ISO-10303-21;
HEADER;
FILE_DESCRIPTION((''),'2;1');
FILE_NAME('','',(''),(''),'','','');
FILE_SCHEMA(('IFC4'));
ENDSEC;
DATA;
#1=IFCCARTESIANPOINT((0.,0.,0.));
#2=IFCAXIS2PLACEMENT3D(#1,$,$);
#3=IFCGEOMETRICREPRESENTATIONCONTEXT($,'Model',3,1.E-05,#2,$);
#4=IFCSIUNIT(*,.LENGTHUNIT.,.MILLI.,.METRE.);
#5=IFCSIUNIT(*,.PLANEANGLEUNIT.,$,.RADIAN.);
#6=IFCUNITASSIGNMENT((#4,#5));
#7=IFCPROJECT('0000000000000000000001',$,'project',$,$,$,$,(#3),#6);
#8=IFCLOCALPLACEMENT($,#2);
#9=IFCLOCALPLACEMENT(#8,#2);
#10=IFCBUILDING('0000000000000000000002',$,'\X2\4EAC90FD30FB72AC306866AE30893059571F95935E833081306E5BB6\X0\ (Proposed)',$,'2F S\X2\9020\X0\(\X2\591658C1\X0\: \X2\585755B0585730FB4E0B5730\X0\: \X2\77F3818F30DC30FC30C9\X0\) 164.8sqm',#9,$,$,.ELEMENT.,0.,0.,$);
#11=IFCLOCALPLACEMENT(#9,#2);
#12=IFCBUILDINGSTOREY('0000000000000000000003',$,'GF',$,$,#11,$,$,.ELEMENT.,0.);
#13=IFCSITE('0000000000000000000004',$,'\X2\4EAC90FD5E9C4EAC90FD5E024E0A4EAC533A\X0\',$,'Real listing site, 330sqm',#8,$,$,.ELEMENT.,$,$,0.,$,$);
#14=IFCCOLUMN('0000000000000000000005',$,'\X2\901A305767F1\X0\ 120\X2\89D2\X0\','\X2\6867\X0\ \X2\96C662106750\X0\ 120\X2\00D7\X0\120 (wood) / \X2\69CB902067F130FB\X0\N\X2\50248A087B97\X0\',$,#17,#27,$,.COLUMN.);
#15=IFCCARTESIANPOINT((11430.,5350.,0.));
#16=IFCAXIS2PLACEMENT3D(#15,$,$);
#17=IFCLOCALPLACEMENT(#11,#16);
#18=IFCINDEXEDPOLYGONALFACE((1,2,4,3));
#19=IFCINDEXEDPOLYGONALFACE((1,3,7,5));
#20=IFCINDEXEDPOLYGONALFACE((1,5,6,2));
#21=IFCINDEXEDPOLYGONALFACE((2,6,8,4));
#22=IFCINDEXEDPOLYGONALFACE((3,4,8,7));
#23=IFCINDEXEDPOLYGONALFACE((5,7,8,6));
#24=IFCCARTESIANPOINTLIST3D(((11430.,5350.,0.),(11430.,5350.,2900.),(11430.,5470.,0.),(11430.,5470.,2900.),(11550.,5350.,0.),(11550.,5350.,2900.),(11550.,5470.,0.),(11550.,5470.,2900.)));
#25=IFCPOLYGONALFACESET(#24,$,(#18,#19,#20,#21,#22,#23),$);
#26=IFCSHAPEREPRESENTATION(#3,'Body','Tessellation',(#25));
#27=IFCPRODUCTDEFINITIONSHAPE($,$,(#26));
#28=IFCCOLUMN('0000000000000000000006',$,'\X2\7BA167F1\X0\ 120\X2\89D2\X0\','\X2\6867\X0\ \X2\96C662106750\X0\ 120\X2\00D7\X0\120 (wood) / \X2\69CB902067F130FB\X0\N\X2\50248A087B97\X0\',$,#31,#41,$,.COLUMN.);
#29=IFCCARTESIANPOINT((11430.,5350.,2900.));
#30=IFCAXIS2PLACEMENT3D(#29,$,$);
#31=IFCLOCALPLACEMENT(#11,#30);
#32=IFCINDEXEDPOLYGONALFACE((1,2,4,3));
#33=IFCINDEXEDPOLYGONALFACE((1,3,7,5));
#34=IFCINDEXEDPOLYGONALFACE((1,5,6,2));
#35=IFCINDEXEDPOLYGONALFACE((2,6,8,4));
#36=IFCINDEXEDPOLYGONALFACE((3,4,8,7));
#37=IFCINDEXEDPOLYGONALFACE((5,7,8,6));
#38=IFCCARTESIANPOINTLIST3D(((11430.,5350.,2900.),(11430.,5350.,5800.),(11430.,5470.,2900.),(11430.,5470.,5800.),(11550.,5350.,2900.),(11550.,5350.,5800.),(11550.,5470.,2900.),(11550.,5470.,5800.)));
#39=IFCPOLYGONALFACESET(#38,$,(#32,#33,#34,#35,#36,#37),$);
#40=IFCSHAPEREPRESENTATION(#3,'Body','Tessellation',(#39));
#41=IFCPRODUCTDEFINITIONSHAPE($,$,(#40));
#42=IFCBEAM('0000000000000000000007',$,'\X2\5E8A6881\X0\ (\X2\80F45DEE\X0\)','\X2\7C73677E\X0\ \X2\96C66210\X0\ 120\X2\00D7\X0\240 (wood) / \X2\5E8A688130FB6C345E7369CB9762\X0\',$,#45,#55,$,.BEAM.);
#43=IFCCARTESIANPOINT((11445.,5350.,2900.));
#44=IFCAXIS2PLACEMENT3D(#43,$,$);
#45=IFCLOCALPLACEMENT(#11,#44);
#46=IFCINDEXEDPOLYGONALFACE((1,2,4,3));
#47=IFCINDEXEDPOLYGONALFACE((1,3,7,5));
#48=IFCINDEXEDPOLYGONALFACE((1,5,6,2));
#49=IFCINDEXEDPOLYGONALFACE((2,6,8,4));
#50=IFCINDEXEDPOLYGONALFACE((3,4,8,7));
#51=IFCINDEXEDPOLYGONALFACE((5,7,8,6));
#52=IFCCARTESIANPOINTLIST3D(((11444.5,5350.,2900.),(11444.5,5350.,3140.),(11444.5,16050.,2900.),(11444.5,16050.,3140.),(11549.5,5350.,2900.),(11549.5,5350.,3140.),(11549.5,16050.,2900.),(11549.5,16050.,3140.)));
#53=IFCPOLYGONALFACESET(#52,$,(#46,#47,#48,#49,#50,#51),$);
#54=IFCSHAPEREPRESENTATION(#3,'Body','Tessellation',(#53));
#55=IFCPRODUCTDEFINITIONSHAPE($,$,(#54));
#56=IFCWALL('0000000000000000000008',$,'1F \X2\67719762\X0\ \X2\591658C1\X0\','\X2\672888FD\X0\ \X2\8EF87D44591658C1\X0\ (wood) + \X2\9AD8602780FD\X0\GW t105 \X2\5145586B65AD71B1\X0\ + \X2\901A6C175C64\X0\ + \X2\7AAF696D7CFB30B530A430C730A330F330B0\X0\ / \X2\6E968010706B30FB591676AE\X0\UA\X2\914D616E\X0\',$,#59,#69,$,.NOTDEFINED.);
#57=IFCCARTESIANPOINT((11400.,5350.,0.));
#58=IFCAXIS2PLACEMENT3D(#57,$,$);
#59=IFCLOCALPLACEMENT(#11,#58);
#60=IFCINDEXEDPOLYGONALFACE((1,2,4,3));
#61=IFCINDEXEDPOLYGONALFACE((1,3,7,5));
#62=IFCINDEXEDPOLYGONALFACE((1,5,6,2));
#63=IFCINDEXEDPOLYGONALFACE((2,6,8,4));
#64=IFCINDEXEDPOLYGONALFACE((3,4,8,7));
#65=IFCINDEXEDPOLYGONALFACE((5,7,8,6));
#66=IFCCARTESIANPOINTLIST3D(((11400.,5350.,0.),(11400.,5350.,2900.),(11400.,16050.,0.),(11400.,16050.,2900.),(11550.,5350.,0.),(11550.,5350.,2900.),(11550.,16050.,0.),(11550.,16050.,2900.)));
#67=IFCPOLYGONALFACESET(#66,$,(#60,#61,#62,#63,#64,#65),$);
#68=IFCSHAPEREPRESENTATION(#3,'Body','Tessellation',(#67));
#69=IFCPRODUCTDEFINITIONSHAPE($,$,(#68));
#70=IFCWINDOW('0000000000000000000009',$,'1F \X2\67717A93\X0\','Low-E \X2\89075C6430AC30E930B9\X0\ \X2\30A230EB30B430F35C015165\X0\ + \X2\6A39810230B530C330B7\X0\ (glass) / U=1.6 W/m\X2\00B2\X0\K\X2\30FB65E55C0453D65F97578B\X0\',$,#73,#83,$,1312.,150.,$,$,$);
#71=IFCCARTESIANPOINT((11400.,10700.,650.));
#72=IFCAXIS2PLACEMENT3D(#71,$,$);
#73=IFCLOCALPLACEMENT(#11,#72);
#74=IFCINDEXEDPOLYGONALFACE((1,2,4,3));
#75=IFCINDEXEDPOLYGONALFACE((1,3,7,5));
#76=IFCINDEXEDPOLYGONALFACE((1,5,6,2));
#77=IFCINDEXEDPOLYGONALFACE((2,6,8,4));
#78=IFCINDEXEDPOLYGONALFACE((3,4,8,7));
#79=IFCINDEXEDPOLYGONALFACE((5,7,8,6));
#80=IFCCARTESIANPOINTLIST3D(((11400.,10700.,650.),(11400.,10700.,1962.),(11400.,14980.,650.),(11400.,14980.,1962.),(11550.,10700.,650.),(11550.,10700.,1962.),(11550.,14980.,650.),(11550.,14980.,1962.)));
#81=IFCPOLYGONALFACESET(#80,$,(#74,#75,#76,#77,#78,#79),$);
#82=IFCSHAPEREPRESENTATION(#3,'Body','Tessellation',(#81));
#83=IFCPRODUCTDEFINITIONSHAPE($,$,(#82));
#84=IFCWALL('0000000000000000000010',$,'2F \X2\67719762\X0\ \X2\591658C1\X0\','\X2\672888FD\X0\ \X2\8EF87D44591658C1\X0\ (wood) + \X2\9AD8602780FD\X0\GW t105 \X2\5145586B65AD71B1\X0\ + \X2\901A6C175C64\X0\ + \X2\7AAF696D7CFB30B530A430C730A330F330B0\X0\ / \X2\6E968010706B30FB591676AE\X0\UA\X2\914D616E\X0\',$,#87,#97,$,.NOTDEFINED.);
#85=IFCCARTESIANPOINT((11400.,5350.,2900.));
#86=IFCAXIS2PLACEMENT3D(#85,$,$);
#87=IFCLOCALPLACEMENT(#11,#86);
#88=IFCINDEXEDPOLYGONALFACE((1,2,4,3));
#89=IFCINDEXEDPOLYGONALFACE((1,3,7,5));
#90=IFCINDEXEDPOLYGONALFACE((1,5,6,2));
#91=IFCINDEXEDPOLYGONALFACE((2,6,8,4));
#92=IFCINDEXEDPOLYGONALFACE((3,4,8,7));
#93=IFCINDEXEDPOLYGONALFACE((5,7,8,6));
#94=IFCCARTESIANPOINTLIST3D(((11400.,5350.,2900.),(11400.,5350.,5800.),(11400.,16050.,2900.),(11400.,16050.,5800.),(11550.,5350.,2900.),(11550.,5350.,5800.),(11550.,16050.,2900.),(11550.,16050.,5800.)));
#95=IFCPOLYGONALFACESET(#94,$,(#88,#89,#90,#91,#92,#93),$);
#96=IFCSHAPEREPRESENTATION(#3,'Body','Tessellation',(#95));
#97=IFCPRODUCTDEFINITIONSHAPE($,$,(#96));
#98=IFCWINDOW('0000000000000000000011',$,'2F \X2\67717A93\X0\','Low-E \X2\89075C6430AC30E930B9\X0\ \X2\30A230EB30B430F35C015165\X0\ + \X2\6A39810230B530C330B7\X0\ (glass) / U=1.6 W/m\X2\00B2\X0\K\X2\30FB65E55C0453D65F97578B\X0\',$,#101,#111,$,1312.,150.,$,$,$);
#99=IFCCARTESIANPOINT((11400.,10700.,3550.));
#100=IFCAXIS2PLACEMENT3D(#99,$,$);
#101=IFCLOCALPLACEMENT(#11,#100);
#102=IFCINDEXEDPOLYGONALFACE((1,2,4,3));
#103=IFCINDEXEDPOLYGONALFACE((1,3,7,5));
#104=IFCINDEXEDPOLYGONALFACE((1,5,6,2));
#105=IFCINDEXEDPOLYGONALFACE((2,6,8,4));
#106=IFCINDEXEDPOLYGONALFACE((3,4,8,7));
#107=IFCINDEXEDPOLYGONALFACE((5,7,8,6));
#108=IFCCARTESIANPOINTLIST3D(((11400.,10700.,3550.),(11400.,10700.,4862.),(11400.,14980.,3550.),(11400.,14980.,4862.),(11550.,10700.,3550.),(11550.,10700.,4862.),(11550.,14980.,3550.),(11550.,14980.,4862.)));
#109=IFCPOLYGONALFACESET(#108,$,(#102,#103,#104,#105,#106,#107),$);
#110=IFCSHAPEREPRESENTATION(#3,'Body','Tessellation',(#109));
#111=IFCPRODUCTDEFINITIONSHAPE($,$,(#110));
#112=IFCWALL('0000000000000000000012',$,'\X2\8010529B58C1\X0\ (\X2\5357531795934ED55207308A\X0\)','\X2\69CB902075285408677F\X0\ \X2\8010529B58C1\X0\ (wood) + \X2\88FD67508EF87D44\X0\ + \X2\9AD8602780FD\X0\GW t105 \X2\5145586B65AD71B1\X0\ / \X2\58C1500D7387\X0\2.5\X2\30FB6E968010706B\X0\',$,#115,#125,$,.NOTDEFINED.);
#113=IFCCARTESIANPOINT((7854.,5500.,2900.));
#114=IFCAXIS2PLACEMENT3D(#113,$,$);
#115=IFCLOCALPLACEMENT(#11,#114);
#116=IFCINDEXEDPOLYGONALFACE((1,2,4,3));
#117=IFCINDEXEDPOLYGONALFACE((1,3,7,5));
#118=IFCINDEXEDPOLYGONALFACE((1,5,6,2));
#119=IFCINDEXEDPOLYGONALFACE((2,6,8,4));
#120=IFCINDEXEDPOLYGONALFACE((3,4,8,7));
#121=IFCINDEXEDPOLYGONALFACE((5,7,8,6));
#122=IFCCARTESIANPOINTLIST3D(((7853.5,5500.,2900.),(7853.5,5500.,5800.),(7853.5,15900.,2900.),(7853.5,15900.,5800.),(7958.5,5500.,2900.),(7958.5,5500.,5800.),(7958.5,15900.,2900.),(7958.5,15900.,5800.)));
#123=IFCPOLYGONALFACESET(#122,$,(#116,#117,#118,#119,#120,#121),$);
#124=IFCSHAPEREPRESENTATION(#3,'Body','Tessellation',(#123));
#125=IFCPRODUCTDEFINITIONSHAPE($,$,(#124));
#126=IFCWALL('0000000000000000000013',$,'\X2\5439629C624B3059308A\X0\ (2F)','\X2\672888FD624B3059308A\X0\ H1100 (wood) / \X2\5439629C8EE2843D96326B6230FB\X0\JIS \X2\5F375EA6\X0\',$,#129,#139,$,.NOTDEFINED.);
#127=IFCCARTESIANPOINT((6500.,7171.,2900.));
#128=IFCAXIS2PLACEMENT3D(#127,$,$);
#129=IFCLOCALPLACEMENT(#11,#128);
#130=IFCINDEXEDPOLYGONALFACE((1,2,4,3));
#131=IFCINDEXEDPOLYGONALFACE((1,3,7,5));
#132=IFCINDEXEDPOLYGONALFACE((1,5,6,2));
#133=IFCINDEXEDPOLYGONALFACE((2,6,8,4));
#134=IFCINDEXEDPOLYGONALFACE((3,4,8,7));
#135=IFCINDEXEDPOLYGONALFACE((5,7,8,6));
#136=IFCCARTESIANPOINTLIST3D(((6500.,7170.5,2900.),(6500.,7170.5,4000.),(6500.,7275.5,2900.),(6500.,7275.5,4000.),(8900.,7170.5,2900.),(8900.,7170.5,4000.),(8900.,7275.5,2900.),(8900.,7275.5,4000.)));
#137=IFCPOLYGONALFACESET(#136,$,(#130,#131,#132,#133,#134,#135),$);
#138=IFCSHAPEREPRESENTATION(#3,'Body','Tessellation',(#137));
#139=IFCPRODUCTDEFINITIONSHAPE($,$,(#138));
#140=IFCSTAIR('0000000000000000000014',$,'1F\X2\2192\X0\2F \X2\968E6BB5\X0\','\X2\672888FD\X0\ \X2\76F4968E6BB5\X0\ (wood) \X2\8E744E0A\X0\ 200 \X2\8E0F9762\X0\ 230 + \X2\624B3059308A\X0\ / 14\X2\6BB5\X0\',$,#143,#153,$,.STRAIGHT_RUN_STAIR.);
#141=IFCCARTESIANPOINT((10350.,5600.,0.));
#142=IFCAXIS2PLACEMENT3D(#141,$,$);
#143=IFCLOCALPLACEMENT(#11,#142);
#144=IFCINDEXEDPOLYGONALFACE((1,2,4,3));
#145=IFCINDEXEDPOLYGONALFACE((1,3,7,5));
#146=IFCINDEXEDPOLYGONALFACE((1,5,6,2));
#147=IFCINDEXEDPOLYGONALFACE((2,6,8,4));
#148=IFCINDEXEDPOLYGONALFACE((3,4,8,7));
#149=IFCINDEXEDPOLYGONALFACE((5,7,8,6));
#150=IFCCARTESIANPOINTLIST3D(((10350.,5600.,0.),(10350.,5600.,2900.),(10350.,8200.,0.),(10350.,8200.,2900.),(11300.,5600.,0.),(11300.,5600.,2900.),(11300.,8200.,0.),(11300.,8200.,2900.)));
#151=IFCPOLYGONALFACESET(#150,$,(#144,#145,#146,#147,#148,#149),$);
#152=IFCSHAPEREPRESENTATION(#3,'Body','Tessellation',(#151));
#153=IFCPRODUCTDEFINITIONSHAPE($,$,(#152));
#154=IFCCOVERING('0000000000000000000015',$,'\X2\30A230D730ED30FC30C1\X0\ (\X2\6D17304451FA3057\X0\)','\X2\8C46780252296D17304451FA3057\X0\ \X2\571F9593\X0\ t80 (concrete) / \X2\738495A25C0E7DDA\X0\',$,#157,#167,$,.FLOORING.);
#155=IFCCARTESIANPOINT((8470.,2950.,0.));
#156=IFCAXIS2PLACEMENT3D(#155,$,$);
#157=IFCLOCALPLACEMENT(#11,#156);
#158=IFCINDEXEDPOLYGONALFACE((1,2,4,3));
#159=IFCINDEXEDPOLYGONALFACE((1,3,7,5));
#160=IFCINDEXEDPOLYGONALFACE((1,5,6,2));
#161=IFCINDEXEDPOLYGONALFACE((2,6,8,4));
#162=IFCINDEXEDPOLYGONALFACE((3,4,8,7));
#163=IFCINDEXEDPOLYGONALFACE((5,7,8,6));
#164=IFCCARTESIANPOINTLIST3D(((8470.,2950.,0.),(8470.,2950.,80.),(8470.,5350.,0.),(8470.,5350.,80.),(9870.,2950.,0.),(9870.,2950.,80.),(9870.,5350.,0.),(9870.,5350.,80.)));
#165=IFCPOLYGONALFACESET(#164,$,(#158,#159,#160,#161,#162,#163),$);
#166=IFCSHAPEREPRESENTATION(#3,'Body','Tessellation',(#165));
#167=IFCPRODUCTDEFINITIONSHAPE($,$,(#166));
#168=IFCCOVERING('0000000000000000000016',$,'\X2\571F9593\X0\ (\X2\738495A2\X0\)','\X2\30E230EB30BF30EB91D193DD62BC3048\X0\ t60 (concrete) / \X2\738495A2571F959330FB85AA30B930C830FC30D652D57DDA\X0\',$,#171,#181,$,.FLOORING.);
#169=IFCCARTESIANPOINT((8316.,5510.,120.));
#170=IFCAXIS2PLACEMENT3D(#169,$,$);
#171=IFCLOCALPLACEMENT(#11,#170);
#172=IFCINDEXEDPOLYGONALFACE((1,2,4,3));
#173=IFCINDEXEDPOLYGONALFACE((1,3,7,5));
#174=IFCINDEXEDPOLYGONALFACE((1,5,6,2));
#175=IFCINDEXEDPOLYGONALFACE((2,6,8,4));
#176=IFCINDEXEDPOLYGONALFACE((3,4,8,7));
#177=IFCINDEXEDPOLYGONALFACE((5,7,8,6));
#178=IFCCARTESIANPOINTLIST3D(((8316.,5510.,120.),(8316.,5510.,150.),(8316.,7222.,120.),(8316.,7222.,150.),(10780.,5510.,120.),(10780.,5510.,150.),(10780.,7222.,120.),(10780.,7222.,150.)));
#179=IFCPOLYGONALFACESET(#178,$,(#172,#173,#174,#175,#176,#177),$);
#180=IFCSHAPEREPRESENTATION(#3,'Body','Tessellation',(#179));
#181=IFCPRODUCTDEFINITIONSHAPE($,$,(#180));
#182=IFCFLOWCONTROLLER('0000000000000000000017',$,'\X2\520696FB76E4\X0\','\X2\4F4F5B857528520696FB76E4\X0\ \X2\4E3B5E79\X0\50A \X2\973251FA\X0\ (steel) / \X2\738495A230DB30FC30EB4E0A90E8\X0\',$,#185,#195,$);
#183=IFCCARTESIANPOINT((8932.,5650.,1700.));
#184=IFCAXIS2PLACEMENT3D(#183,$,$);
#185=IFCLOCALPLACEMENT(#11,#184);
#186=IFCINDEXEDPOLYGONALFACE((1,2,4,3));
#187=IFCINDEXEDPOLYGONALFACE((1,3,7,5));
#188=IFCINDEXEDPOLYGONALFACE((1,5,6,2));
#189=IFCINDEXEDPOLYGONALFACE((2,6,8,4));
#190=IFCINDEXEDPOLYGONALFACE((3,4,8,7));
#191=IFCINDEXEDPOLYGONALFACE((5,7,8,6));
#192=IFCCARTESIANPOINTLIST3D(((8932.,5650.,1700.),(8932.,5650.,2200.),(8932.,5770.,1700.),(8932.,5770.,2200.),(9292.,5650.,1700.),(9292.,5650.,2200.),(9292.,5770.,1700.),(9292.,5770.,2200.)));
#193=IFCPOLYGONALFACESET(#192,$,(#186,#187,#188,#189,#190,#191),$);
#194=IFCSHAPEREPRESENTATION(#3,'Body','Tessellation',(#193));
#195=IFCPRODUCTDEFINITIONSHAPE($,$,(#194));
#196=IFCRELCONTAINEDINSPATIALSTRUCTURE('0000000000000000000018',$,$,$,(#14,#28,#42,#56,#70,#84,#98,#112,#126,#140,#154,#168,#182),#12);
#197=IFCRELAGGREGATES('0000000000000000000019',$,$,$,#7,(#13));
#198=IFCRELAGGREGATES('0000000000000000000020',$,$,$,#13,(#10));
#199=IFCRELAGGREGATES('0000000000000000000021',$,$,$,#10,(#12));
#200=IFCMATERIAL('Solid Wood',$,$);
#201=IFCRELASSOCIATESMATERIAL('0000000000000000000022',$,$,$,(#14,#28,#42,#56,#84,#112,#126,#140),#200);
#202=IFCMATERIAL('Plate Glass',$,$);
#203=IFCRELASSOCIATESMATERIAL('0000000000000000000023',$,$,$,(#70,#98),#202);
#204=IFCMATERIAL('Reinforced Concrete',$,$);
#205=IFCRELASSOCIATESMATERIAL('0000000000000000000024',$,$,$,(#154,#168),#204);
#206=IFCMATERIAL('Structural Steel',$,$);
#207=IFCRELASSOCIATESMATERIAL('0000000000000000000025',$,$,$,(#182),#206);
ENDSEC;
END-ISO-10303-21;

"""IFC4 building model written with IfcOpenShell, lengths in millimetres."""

from ifc_helpers import new_model, si_unit, frame, frame_2d, origin, place, context, project, spatial, rectangle, extrude, material, element, fill, save


model = new_model("IFC4")

# Units and contexts
model_context = context("Model", 3, precision=1e-05, world=origin())
ifc_project = project(units=[si_unit("LENGTHUNIT", "METRE", prefix="MILLI"), si_unit("PLANEANGLEUNIT", "RADIAN")], contexts=[model_context])

# Site, building, storey
site_placement = place(None, origin())
site = spatial("IfcSite", under=ifc_project, at=site_placement, Name="京都府京都市上京区", ObjectType="Real listing site, 330sqm", CompositionType="ELEMENT", RefElevation=0.0)
building_placement = place(site_placement, origin())
building = spatial("IfcBuilding", under=site, at=building_placement, Name="京都・犬と暮らす土間広めの家 (Proposed)", ObjectType="2F S造(外壁: 塗喰塗・下地: 石膏ボード) 164.8sqm", CompositionType="ELEMENT", ElevationOfRefHeight=0.0, ElevationOfTerrain=0.0)
storey_placement = place(building_placement, origin())
storey = spatial("IfcBuildingStorey", under=building, at=storey_placement, Name="GF", CompositionType="ELEMENT", Elevation=0.0)

# Columns
ifc_material_1 = material(Name="Solid Wood")
column_1_placement = place(storey_placement, frame((11430.0, 5350.0, 0.0)))
element("IfcColumn", 1, at=column_1_placement, inside=storey, material=ifc_material_1, Name="通し柱 120角", Description="桧 集成材 120×120 (wood) / 構造柱・N値計算", PredefinedType="COLUMN", context=model_context, shape_type="SweptSolid", body=[
    extrude(rectangle(XDim=120.0, YDim=120.0, at=frame_2d((60.0, 60.0))), frame((11430.0, 5350.0, 0.0)), (0.0, 0.0, 1.0), 2900.0),
])
column_2_placement = place(storey_placement, frame((11430.0, 5350.0, 2900.0)))
element("IfcColumn", 2, at=column_2_placement, inside=storey, material=ifc_material_1, Name="管柱 120角", Description="桧 集成材 120×120 (wood) / 構造柱・N値計算", PredefinedType="COLUMN", context=model_context, shape_type="SweptSolid", body=[
    extrude(rectangle(XDim=120.0, YDim=120.0, at=frame_2d((60.0, 60.0))), frame((11430.0, 5350.0, 2900.0)), (0.0, 0.0, 1.0), 2900.0),
])

# Beam
beam_1_placement = place(storey_placement, frame((11445.0, 5350.0, 2900.0)))
element("IfcBeam", 3, at=beam_1_placement, inside=storey, material=ifc_material_1, Name="床梁 (胴差)", Description="米松 集成 120×240 (wood) / 床梁・水平構面", PredefinedType="BEAM", context=model_context, shape_type="SweptSolid", body=[
    extrude(rectangle(XDim=105.0, YDim=10700.0, at=frame_2d((52.0, 5350.0))), frame((11445.0, 5350.0, 2900.0)), (0.0, 0.0, 1.0), 240.0),
])

# Wall, opening, window
wall_1_placement = place(storey_placement, frame((11400.0, 5350.0, 0.0)))
wall_1 = element("IfcWall", 4, at=wall_1_placement, inside=storey, material=ifc_material_1, Name="1F 東面 外壁", Description="木製 軸組外壁 (wood) + 高性能GW t105 充填断熱 + 通気層 + 窯業系サイディング / 準耐火・外皮UA配慮", PredefinedType="NOTDEFINED", context=model_context, shape_type="SweptSolid", body=[
    extrude(rectangle(XDim=150.0, YDim=10700.0, at=frame_2d((75.0, 5350.0))), frame((11400.0, 5350.0, 0.0)), (0.0, 0.0, 1.0), 2900.0),
])
opening_1_placement = place(storey_placement, frame((11400.0, 10700.0, 650.0)))
opening_1 = element("IfcOpeningElement", 5, at=opening_1_placement, cuts=wall_1, PredefinedType="NOTDEFINED", context=model_context, shape_type="SweptSolid", body=[
    extrude(rectangle(XDim=150.0, YDim=4280.0, at=frame_2d((75.0, 2140.0))), frame((11400.0, 10700.0, 650.0)), (0.0, 0.0, 1.0), 1312.0),
])
ifc_material_2 = material(Name="Plate Glass")
window_1_placement = place(storey_placement, frame((11400.0, 10700.0, 650.0)))
window_1 = element("IfcWindow", 6, at=window_1_placement, inside=storey, material=ifc_material_2, Name="1F 東窓", Description="Low-E 複層ガラス アルゴン封入 + 樹脂サッシ (glass) / U=1.6 W/m²K・日射取得型", OverallHeight=1312.0, OverallWidth=150.0, context=model_context, shape_type="SweptSolid", body=[
    extrude(rectangle(XDim=150.0, YDim=4280.0, at=frame_2d((75.0, 2140.0))), frame((11400.0, 10700.0, 650.0)), (0.0, 0.0, 1.0), 1312.0),
])
fill(opening_1, window_1)

# Wall, opening, window
wall_2_placement = place(storey_placement, frame((11400.0, 5350.0, 2900.0)))
wall_2 = element("IfcWall", 7, at=wall_2_placement, inside=storey, material=ifc_material_1, Name="2F 東面 外壁", Description="木製 軸組外壁 (wood) + 高性能GW t105 充填断熱 + 通気層 + 窯業系サイディング / 準耐火・外皮UA配慮", PredefinedType="NOTDEFINED", context=model_context, shape_type="SweptSolid", body=[
    extrude(rectangle(XDim=150.0, YDim=10700.0, at=frame_2d((75.0, 5350.0))), frame((11400.0, 5350.0, 2900.0)), (0.0, 0.0, 1.0), 2900.0),
])
opening_2_placement = place(storey_placement, frame((11400.0, 10700.0, 3550.0)))
opening_2 = element("IfcOpeningElement", 8, at=opening_2_placement, cuts=wall_2, PredefinedType="NOTDEFINED", context=model_context, shape_type="SweptSolid", body=[
    extrude(rectangle(XDim=150.0, YDim=4280.0, at=frame_2d((75.0, 2140.0))), frame((11400.0, 10700.0, 3550.0)), (0.0, 0.0, 1.0), 1312.0),
])
window_2_placement = place(storey_placement, frame((11400.0, 10700.0, 3550.0)))
window_2 = element("IfcWindow", 9, at=window_2_placement, inside=storey, material=ifc_material_2, Name="2F 東窓", Description="Low-E 複層ガラス アルゴン封入 + 樹脂サッシ (glass) / U=1.6 W/m²K・日射取得型", OverallHeight=1312.0, OverallWidth=150.0, context=model_context, shape_type="SweptSolid", body=[
    extrude(rectangle(XDim=150.0, YDim=4280.0, at=frame_2d((75.0, 2140.0))), frame((11400.0, 10700.0, 3550.0)), (0.0, 0.0, 1.0), 1312.0),
])
fill(opening_2, window_2)

# Walls
wall_3_placement = place(storey_placement, frame((7854.0, 5500.0, 2900.0)))
element("IfcWall", 10, at=wall_3_placement, inside=storey, material=ifc_material_1, Name="耐力壁 (南北間仕切り)", Description="構造用合板 耐力壁 (wood) + 製材軸組 + 高性能GW t105 充填断熱 / 壁倍率2.5・準耐火", PredefinedType="NOTDEFINED", context=model_context, shape_type="SweptSolid", body=[
    extrude(rectangle(XDim=105.0, YDim=10400.0, at=frame_2d((52.0, 5200.0))), frame((7854.0, 5500.0, 2900.0)), (0.0, 0.0, 1.0), 2900.0),
])
wall_4_placement = place(storey_placement, frame((6500.0, 7171.0, 2900.0)))
element("IfcWall", 11, at=wall_4_placement, inside=storey, material=ifc_material_1, Name="吹抜手すり (2F)", Description="木製手すり H1100 (wood) / 吹抜転落防止・JIS 強度", PredefinedType="NOTDEFINED", context=model_context, shape_type="SweptSolid", body=[
    extrude(rectangle(XDim=2400.0, YDim=105.0, at=frame_2d((1200.0, 52.0))), frame((6500.0, 7171.0, 2900.0)), (0.0, 0.0, 1.0), 1100.0),
])

# Stair
stair_placement = place(storey_placement, frame((10350.0, 5600.0, 0.0)))
element("IfcStair", 12, at=stair_placement, inside=storey, material=ifc_material_1, Name="1F→2F 階段", Description="木製 直階段 (wood) 蹴上 200 踏面 230 + 手すり / 14段", PredefinedType="STRAIGHT_RUN_STAIR", context=model_context, shape_type="SweptSolid", body=[
    extrude(rectangle(XDim=950.0, YDim=2600.0, at=frame_2d((475.0, 1300.0))), frame((10350.0, 5600.0, 0.0)), (0.0, 0.0, 1.0), 2900.0),
])

# Coverings
ifc_material_3 = material(Name="Reinforced Concrete")
covering_1_placement = place(storey_placement, frame((8470.0, 2950.0, 0.0)))
element("IfcCovering", 13, at=covering_1_placement, inside=storey, material=ifc_material_3, Name="アプローチ (洗い出し)", Description="豆砂利洗い出し 土間 t80 (concrete) / 玄関導線", PredefinedType="FLOORING", context=model_context, shape_type="SweptSolid", body=[
    extrude(rectangle(XDim=1400.0, YDim=2400.0, at=frame_2d((700.0, 1200.0))), frame((8470.0, 2950.0, 0.0)), (0.0, 0.0, 1.0), 80.0),
])
covering_2_placement = place(storey_placement, frame((8316.0, 5510.0, 120.0)))
element("IfcCovering", 14, at=covering_2_placement, inside=storey, material=ifc_material_3, Name="土間 (玄関)", Description="モルタル金鏝押え t60 (concrete) / 玄関土間・薪ストーブ動線", PredefinedType="FLOORING", context=model_context, shape_type="SweptSolid", body=[
    extrude(rectangle(XDim=2464.0, YDim=1712.0, at=frame_2d((1232.0, 856.0))), frame((8316.0, 5510.0, 120.0)), (0.0, 0.0, 1.0), 30.0),
])

# Flow controller
ifc_material_4 = material(Name="Structural Steel")
flow_controller_placement = place(storey_placement, frame((8932.0, 5650.0, 1700.0)))
element("IfcFlowController", 15, at=flow_controller_placement, inside=storey, material=ifc_material_4, Name="分電盤", Description="住宅用分電盤 主幹50A 露出 (steel) / 玄関ホール上部", context=model_context, shape_type="SweptSolid", body=[
    extrude(rectangle(XDim=360.0, YDim=120.0, at=frame_2d((180.0, 60.0))), frame((8932.0, 5650.0, 1700.0)), (0.0, 0.0, 1.0), 500.0),
])

save(model, "model.ifc")
